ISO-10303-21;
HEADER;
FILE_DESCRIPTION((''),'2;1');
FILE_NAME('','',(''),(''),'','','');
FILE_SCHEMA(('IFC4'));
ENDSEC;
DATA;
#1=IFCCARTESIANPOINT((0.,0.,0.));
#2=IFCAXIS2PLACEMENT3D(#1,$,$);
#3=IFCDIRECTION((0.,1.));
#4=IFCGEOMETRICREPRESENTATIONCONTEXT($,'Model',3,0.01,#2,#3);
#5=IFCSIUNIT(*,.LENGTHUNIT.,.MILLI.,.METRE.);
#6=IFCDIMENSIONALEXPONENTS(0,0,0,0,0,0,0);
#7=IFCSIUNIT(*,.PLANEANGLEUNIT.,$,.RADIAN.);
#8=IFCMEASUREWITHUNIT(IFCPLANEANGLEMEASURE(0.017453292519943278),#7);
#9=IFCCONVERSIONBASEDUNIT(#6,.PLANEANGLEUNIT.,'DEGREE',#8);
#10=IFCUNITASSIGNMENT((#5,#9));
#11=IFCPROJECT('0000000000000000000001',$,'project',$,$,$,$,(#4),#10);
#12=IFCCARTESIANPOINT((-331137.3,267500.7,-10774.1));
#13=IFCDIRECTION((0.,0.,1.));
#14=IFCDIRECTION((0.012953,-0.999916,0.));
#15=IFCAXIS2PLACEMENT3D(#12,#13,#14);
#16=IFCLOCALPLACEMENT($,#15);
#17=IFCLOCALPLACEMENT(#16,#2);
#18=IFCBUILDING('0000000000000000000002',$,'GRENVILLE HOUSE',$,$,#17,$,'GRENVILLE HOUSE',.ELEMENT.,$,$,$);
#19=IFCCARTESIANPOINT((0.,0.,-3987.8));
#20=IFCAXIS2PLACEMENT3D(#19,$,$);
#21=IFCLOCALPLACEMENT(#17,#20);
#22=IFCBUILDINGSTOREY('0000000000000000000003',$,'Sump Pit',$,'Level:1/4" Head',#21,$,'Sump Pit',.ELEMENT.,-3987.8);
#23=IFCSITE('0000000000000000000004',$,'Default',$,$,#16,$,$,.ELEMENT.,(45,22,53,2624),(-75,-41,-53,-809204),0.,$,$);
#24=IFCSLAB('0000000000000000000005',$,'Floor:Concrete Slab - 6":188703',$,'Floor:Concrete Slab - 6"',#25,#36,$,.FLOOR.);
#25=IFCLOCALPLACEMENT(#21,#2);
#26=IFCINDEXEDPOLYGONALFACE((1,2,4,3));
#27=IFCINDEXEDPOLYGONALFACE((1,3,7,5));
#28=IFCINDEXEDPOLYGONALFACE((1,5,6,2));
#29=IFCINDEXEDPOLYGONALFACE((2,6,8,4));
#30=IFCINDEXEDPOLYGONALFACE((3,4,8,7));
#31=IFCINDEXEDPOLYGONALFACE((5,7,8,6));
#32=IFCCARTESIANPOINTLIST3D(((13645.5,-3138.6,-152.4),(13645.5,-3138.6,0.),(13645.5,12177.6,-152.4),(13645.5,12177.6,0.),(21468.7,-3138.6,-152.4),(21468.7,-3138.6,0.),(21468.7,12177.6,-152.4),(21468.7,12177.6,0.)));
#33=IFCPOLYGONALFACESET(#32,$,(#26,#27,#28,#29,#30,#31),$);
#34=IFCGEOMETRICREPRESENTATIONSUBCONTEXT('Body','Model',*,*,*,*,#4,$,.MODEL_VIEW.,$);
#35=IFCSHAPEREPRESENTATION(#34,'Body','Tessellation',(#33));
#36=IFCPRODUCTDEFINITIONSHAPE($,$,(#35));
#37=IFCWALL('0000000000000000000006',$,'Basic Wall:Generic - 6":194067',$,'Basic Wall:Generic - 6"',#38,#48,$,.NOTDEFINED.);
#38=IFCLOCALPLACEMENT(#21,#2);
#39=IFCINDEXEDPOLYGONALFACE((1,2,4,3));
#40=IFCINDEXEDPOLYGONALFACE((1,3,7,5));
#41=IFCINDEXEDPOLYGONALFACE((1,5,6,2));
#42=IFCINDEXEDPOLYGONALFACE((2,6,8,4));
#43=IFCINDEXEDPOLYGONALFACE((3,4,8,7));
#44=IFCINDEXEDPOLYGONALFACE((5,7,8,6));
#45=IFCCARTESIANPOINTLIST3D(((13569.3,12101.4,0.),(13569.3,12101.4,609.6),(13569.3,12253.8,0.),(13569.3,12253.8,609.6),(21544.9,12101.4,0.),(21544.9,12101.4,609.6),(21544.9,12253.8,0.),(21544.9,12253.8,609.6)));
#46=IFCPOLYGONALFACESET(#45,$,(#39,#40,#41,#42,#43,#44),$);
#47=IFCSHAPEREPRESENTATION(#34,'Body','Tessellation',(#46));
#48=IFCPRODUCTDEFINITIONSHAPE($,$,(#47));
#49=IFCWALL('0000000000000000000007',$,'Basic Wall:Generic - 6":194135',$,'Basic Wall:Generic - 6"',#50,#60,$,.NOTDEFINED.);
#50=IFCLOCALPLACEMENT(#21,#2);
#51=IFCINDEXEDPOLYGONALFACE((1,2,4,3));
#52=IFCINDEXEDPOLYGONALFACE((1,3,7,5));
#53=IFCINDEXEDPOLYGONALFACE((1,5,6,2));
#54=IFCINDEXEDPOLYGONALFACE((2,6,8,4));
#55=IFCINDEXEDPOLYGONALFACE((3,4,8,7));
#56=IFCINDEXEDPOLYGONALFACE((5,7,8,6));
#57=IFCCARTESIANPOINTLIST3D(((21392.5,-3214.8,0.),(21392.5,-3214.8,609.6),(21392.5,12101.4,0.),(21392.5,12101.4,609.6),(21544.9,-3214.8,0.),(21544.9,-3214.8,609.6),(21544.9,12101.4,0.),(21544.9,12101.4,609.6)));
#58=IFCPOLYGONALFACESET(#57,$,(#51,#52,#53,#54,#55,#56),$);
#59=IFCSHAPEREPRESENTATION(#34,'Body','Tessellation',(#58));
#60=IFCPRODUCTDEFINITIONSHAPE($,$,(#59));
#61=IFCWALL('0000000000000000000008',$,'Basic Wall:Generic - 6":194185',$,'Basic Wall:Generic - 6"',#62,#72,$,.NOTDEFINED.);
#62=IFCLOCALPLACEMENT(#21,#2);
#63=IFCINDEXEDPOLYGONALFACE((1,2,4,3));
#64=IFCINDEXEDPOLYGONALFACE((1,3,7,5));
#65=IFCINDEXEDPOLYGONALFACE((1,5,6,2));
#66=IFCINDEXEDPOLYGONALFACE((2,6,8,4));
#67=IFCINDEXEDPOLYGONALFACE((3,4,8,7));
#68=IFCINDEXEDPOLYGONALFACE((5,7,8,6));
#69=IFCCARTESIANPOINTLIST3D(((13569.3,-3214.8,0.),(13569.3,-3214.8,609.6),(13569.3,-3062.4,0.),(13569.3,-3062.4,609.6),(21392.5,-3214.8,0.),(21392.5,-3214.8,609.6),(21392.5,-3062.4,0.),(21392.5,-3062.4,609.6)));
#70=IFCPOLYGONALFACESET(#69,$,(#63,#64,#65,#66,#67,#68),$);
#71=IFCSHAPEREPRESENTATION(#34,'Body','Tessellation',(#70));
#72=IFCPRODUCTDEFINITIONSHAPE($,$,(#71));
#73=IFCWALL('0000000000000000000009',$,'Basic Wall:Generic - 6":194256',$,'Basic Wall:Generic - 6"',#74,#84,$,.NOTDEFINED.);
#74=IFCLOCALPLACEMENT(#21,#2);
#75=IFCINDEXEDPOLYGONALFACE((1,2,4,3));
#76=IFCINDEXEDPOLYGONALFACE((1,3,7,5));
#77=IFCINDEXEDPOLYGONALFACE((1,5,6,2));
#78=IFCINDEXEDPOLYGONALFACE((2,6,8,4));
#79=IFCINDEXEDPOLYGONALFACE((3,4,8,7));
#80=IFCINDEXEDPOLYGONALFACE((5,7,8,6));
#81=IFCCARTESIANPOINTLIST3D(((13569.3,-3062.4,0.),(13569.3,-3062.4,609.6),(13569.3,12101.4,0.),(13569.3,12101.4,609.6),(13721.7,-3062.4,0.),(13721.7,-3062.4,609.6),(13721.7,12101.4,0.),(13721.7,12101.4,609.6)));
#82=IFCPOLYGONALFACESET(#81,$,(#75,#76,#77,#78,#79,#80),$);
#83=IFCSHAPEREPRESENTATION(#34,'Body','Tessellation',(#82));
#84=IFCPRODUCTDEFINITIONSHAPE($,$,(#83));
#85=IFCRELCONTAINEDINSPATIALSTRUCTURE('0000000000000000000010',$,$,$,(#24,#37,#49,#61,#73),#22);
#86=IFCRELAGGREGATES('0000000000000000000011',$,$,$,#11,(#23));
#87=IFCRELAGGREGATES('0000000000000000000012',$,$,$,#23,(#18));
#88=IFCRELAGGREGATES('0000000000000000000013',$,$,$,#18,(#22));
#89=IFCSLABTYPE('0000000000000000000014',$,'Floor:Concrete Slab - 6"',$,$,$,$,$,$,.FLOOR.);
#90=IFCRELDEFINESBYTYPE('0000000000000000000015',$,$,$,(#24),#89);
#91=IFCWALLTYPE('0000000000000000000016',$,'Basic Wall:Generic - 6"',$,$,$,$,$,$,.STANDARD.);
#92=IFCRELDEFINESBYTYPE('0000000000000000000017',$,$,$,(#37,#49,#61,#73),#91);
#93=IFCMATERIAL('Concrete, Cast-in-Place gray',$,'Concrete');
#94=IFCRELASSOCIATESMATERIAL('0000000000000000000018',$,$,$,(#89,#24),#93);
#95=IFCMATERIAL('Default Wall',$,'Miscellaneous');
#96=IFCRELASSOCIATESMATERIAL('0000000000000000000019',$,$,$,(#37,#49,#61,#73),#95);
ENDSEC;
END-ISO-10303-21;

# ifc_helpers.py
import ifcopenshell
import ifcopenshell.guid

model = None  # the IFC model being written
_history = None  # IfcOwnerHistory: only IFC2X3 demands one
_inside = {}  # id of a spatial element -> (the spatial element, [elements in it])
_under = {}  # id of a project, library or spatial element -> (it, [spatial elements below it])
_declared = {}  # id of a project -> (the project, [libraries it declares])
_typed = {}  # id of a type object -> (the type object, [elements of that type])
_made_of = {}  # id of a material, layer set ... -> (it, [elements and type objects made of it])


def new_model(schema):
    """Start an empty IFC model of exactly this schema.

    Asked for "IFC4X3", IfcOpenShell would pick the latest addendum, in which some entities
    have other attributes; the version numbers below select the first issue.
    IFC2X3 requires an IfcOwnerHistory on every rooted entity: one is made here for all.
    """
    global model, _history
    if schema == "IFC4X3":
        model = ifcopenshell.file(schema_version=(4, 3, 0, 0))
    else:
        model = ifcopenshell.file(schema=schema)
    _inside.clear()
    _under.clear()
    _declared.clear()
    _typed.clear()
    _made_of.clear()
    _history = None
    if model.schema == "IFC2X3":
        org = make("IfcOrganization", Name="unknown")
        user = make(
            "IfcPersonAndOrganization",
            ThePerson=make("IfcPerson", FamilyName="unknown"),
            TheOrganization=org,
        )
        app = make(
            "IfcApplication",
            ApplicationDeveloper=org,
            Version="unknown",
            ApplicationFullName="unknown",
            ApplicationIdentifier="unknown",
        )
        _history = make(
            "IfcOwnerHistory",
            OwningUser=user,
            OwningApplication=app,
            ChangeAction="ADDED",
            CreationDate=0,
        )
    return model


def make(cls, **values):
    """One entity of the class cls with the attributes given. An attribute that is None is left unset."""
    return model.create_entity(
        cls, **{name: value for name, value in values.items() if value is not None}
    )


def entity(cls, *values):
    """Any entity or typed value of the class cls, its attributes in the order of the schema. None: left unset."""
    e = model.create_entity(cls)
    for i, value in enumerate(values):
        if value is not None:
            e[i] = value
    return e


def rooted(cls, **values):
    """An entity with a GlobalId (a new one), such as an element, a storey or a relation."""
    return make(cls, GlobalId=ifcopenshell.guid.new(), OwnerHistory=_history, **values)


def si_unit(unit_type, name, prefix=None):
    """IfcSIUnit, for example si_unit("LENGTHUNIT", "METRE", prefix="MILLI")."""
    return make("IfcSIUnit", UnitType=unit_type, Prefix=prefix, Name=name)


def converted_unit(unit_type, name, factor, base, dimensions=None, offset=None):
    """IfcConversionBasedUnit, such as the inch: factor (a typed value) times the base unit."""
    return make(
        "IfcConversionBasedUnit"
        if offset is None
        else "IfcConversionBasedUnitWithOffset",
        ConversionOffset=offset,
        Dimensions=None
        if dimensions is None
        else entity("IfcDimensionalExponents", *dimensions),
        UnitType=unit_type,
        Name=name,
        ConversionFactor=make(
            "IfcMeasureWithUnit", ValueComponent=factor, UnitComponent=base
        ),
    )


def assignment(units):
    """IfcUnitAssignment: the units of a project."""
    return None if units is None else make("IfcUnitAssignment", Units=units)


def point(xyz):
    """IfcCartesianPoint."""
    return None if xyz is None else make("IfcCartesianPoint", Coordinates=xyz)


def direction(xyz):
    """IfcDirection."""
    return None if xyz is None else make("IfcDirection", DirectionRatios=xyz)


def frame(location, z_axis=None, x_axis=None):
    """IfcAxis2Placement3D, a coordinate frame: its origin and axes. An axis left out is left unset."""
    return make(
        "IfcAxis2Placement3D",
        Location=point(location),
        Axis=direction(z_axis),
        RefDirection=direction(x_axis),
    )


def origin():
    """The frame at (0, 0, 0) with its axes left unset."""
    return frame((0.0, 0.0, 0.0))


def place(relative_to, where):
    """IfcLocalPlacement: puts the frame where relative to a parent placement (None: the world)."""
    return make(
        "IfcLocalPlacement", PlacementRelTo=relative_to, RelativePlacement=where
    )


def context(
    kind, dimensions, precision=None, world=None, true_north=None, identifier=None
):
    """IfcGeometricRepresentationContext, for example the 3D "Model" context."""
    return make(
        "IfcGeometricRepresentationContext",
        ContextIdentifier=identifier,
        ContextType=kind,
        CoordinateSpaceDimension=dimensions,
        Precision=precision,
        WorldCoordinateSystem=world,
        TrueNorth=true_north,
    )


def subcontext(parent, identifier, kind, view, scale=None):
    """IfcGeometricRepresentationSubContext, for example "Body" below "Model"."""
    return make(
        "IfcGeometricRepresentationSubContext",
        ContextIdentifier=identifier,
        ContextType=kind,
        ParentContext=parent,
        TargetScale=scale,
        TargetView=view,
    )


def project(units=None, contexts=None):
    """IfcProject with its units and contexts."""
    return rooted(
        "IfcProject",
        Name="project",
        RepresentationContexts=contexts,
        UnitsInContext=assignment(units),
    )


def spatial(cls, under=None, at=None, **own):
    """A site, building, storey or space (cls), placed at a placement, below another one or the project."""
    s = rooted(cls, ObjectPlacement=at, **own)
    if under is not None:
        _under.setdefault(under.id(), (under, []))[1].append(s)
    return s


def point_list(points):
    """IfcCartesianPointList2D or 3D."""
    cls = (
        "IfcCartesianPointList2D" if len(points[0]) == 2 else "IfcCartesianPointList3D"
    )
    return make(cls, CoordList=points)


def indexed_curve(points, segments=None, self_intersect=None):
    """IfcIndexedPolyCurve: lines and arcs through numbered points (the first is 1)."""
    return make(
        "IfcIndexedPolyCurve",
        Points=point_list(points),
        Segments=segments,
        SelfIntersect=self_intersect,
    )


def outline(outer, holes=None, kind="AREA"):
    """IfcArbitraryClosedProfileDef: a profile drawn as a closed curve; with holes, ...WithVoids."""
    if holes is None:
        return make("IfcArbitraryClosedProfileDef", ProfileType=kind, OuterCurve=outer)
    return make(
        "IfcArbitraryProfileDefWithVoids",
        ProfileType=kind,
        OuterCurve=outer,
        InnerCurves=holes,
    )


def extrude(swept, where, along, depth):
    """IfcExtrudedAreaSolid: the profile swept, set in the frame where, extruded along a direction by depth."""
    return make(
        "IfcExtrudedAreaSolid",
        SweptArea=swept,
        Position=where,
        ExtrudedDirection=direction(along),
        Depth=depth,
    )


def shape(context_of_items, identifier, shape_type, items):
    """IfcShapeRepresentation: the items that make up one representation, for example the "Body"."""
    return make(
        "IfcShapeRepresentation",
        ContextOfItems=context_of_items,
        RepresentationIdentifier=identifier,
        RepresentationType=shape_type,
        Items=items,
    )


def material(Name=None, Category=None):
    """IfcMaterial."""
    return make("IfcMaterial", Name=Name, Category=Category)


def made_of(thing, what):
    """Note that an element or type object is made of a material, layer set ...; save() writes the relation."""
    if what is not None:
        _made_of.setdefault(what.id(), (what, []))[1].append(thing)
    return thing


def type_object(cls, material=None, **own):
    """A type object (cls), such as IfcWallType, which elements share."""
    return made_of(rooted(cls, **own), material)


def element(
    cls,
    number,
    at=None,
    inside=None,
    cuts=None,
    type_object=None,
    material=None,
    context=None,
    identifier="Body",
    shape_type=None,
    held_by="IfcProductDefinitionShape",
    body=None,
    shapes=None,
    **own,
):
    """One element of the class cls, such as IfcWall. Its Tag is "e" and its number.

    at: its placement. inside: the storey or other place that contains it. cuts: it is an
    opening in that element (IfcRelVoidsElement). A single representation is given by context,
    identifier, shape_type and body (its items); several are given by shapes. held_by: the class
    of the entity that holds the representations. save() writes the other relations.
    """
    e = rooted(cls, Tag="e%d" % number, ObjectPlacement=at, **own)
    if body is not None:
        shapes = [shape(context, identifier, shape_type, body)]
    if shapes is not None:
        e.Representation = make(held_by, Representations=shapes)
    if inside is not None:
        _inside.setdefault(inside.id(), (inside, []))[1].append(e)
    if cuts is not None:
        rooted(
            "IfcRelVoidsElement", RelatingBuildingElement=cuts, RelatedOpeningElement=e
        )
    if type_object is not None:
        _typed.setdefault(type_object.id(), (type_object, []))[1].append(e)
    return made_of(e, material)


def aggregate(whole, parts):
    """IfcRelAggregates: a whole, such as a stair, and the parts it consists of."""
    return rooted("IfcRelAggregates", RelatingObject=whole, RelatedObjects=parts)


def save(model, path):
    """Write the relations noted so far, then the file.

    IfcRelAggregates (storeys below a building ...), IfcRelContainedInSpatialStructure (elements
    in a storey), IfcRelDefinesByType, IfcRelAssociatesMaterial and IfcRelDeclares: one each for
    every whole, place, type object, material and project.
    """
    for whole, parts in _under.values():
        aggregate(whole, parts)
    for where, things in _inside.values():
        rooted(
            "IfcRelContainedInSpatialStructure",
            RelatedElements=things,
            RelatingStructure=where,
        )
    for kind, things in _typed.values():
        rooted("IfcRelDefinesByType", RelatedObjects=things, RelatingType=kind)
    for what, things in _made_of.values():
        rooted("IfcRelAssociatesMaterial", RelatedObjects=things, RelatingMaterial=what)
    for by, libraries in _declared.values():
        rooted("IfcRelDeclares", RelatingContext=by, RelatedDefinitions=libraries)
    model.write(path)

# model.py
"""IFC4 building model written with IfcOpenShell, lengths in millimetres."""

from ifc_helpers import new_model, entity, si_unit, converted_unit, direction, frame, origin, place, context, subcontext, project, spatial, indexed_curve, outline, extrude, material, type_object, element, save


model = new_model("IFC4")

# Units and contexts
model_context = context("Model", 3, precision=0.01, world=origin(), true_north=direction((0.0, 1.0)))
body_context = subcontext(model_context, "Body", "Model", "MODEL_VIEW")
ifc_project = project(units=[si_unit("LENGTHUNIT", "METRE", prefix="MILLI"), converted_unit("PLANEANGLEUNIT", "DEGREE", entity("IfcPlaneAngleMeasure", 0.017453292519943278), si_unit("PLANEANGLEUNIT", "RADIAN"), dimensions=[0, 0, 0, 0, 0, 0, 0])], contexts=[model_context])

# Site, building, storey
site_placement = place(None, frame((-331137.3, 267500.7, -10774.1), z_axis=(0.0, 0.0, 1.0), x_axis=(0.012953, -0.999916, 0.0)))
site = spatial("IfcSite", under=ifc_project, at=site_placement, Name="Default", CompositionType="ELEMENT", RefLatitude=(45, 22, 53, 2624), RefLongitude=(-75, -41, -53, -809204), RefElevation=0.0)
building_placement = place(site_placement, origin())
building = spatial("IfcBuilding", under=site, at=building_placement, Name="GRENVILLE HOUSE", LongName="GRENVILLE HOUSE", CompositionType="ELEMENT")
storey_placement = place(building_placement, frame((0.0, 0.0, -3987.8)))
storey = spatial("IfcBuildingStorey", under=building, at=storey_placement, Name="Sump Pit", ObjectType="Level:1/4\" Head", LongName="Sump Pit", CompositionType="ELEMENT", Elevation=-3987.8)

# Slab
ifc_material_1 = material(Name="Concrete, Cast-in-Place gray", Category="Concrete")
slab_type = type_object("IfcSlabType", Name="Floor:Concrete Slab - 6\"", PredefinedType="FLOOR", material=ifc_material_1)
slab_placement = place(storey_placement, origin())
element("IfcSlab", 1, at=slab_placement, inside=storey, type_object=slab_type, material=ifc_material_1, Name="Floor:Concrete Slab - 6\":188703", ObjectType="Floor:Concrete Slab - 6\"", PredefinedType="FLOOR", context=body_context, shape_type="SweptSolid", body=[
    extrude(outline(indexed_curve([(-7658.1, -3911.6), (7658.1, -3911.6), (7658.1, 3911.6), (-7658.1, 3911.6), (-7658.1, -3911.6)], self_intersect=False)), frame((17557.1, 4519.5, 0.0), z_axis=(0.0, 0.0, -1.0), x_axis=(0.0, 1.0, 0.0)), (0.0, 0.0, 1.0), 152.4),
])

# Walls
ifc_material_2 = material(Name="Default Wall", Category="Miscellaneous")
wall_type = type_object("IfcWallType", Name="Basic Wall:Generic - 6\"", PredefinedType="STANDARD")
wall_1_placement = place(storey_placement, frame((13569.3, 12177.6, 0.0)))
element("IfcWall", 2, at=wall_1_placement, inside=storey, type_object=wall_type, material=ifc_material_2, Name="Basic Wall:Generic - 6\":194067", ObjectType="Basic Wall:Generic - 6\"", PredefinedType="NOTDEFINED", context=body_context, shape_type="SweptSolid", body=[
    extrude(outline(indexed_curve([(7975.6, 76.2), (0.0, 76.2), (0.0, -76.2), (7975.6, -76.2), (7975.6, 76.2)], self_intersect=False)), origin(), (0.0, 0.0, 1.0), 609.6),
])
wall_2_placement = place(storey_placement, frame((21468.7, 12101.4, 0.0), z_axis=(0.0, 0.0, 1.0), x_axis=(0.0, -1.0, 0.0)))
element("IfcWall", 3, at=wall_2_placement, inside=storey, type_object=wall_type, material=ifc_material_2, Name="Basic Wall:Generic - 6\":194135", ObjectType="Basic Wall:Generic - 6\"", PredefinedType="NOTDEFINED", context=body_context, shape_type="SweptSolid", body=[
    extrude(outline(indexed_curve([(15316.2, 76.2), (0.0, 76.2), (0.0, -76.2), (15316.2, -76.2), (15316.2, 76.2)], self_intersect=False)), origin(), (0.0, 0.0, 1.0), 609.6),
])
wall_3_placement = place(storey_placement, frame((21392.5, -3138.6, 0.0), z_axis=(0.0, 0.0, 1.0), x_axis=(-1.0, 0.0, 0.0)))
element("IfcWall", 4, at=wall_3_placement, inside=storey, type_object=wall_type, material=ifc_material_2, Name="Basic Wall:Generic - 6\":194185", ObjectType="Basic Wall:Generic - 6\"", PredefinedType="NOTDEFINED", context=body_context, shape_type="SweptSolid", body=[
    extrude(outline(indexed_curve([(7823.2, 76.2), (0.0, 76.2), (0.0, -76.2), (7823.2, -76.2), (7823.2, 76.2)], self_intersect=False)), origin(), (0.0, 0.0, 1.0), 609.6),
])
wall_4_placement = place(storey_placement, frame((13645.5, -3062.4, 0.0), z_axis=(0.0, 0.0, 1.0), x_axis=(0.0, 1.0, 0.0)))
element("IfcWall", 5, at=wall_4_placement, inside=storey, type_object=wall_type, material=ifc_material_2, Name="Basic Wall:Generic - 6\":194256", ObjectType="Basic Wall:Generic - 6\"", PredefinedType="NOTDEFINED", context=body_context, shape_type="SweptSolid", body=[
    extrude(outline(indexed_curve([(15163.8, 76.2), (0.0, 76.2), (0.0, -76.2), (15163.8, -76.2), (15163.8, 76.2)], self_intersect=False)), origin(), (0.0, 0.0, 1.0), 609.6),
])

save(model, "model.ifc")
